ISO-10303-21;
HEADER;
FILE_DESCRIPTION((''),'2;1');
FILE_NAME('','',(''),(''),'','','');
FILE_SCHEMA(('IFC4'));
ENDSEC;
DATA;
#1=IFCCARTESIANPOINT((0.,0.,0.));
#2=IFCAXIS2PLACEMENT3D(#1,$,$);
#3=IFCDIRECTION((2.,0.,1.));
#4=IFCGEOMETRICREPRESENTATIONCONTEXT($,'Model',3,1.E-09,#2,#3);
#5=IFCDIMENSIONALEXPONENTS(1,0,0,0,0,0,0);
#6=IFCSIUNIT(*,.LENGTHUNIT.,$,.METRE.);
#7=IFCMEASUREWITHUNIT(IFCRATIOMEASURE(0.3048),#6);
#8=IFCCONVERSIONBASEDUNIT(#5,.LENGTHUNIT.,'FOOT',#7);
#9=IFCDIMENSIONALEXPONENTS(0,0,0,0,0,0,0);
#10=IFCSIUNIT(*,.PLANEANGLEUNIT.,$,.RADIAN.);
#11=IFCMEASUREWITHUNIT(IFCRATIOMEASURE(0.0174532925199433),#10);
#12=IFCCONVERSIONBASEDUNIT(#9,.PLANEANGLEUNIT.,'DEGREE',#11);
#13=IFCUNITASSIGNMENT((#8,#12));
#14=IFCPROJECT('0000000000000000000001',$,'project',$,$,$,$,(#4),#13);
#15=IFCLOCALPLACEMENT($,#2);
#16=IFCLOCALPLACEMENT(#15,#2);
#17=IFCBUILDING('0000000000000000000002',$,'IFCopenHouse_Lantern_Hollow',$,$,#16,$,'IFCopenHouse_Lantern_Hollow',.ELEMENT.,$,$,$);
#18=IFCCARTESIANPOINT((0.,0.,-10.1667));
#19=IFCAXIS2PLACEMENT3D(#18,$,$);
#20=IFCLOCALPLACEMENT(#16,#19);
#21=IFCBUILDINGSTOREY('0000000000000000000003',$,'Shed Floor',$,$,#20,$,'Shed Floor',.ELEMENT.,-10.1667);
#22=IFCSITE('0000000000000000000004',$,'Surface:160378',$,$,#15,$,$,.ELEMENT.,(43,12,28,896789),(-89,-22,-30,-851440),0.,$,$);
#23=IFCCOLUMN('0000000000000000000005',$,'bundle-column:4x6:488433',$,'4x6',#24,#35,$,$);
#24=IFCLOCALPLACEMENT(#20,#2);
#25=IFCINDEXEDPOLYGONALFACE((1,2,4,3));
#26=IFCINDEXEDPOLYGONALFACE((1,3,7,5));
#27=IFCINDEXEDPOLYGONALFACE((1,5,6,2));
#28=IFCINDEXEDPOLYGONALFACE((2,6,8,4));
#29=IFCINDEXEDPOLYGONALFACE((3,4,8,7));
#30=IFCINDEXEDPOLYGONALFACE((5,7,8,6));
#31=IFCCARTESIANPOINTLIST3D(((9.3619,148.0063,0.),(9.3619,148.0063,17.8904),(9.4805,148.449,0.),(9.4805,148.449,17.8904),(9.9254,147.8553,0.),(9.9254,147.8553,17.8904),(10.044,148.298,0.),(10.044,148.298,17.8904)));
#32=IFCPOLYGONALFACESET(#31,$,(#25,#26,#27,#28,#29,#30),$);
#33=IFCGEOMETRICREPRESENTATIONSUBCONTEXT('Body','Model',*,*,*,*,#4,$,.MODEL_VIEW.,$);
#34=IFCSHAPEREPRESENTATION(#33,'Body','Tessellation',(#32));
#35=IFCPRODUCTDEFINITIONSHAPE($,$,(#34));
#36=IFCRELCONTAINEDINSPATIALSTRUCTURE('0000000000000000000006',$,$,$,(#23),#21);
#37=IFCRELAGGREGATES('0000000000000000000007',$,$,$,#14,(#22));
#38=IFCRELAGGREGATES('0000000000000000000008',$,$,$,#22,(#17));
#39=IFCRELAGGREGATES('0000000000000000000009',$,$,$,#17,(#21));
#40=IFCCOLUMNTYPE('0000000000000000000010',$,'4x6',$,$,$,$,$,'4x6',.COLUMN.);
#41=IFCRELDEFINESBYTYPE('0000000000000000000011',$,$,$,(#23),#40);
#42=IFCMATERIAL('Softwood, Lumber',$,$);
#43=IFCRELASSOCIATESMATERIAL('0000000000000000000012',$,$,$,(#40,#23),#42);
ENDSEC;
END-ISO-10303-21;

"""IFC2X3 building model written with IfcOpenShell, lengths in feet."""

from ifc_helpers import new_model, entity, si_unit, converted_unit, direction, frame, frame_2d, origin, place, context, subcontext, project, spatial, rectangle, extrude, source, transform, mapped, material, type_object, type_shapes, element, save


model = new_model("IFC2X3")

# Units and contexts
model_context = context("Model", 3, precision=1e-09, world=origin(), true_north=direction((2.0, 0.0, 1.0)))
body_context = subcontext(model_context, "Body", "Model", "MODEL_VIEW")
ifc_project = project(units=[converted_unit("LENGTHUNIT", "FOOT", entity("IfcRatioMeasure", 0.3048), si_unit("LENGTHUNIT", "METRE"), dimensions=[1, 0, 0, 0, 0, 0, 0]), converted_unit("PLANEANGLEUNIT", "DEGREE", entity("IfcRatioMeasure", 0.0174532925199433), si_unit("PLANEANGLEUNIT", "RADIAN"), dimensions=[0, 0, 0, 0, 0, 0, 0])], contexts=[model_context])

# Site, building, storey
site_placement = place(None, origin())
site = spatial("IfcSite", under=ifc_project, at=site_placement, Name="Surface:160378", CompositionType="ELEMENT", RefLatitude=(43, 12, 28, 896789), RefLongitude=(-89, -22, -30, -851440), RefElevation=0.0)
building_placement = place(site_placement, origin())
building = spatial("IfcBuilding", under=site, at=building_placement, Name="IFCopenHouse_Lantern_Hollow", LongName="IFCopenHouse_Lantern_Hollow", CompositionType="ELEMENT")
storey_placement = place(building_placement, frame((0.0, 0.0, -10.1667)))
storey = spatial("IfcBuildingStorey", under=building, at=storey_placement, Name="Shed Floor", LongName="Shed Floor", CompositionType="ELEMENT", Elevation=-10.1667)

# Column
ifc_material_1 = material(Name="Softwood, Lumber")
column_type_1 = type_object("IfcColumnType", Name="4x6", ElementType="4x6", PredefinedType="COLUMN", material=ifc_material_1)
shared_shape_1 = source(origin(), body_context, "Body", "SweptSolid", [
    extrude(rectangle(XDim=0.5833, YDim=0.4583, at=frame_2d((0.0, 0.0), x_axis=(1.0, 0.0))), frame((9.7029, 148.1521, -10.1667), z_axis=(0.0, 0.0, 1.0), x_axis=(-0.965926, 0.258819, 0.0)), (0.0, 0.0, 1.0), 17.8904),
])
type_shapes(column_type_1, [shared_shape_1])
column_1_placement = place(storey_placement, frame((0.0, 0.0, 10.1667)))
element("IfcColumn", 1, at=column_1_placement, inside=storey, type_object=column_type_1, material=ifc_material_1, Name="bundle-column:4x6:488433", ObjectType="4x6", context=body_context, shape_type="MappedRepresentation", body=[
    mapped(shared_shape_1, transform((0.0, 0.0, 0.0), scale=1.0)),
])

save(model, "model.ifc")
